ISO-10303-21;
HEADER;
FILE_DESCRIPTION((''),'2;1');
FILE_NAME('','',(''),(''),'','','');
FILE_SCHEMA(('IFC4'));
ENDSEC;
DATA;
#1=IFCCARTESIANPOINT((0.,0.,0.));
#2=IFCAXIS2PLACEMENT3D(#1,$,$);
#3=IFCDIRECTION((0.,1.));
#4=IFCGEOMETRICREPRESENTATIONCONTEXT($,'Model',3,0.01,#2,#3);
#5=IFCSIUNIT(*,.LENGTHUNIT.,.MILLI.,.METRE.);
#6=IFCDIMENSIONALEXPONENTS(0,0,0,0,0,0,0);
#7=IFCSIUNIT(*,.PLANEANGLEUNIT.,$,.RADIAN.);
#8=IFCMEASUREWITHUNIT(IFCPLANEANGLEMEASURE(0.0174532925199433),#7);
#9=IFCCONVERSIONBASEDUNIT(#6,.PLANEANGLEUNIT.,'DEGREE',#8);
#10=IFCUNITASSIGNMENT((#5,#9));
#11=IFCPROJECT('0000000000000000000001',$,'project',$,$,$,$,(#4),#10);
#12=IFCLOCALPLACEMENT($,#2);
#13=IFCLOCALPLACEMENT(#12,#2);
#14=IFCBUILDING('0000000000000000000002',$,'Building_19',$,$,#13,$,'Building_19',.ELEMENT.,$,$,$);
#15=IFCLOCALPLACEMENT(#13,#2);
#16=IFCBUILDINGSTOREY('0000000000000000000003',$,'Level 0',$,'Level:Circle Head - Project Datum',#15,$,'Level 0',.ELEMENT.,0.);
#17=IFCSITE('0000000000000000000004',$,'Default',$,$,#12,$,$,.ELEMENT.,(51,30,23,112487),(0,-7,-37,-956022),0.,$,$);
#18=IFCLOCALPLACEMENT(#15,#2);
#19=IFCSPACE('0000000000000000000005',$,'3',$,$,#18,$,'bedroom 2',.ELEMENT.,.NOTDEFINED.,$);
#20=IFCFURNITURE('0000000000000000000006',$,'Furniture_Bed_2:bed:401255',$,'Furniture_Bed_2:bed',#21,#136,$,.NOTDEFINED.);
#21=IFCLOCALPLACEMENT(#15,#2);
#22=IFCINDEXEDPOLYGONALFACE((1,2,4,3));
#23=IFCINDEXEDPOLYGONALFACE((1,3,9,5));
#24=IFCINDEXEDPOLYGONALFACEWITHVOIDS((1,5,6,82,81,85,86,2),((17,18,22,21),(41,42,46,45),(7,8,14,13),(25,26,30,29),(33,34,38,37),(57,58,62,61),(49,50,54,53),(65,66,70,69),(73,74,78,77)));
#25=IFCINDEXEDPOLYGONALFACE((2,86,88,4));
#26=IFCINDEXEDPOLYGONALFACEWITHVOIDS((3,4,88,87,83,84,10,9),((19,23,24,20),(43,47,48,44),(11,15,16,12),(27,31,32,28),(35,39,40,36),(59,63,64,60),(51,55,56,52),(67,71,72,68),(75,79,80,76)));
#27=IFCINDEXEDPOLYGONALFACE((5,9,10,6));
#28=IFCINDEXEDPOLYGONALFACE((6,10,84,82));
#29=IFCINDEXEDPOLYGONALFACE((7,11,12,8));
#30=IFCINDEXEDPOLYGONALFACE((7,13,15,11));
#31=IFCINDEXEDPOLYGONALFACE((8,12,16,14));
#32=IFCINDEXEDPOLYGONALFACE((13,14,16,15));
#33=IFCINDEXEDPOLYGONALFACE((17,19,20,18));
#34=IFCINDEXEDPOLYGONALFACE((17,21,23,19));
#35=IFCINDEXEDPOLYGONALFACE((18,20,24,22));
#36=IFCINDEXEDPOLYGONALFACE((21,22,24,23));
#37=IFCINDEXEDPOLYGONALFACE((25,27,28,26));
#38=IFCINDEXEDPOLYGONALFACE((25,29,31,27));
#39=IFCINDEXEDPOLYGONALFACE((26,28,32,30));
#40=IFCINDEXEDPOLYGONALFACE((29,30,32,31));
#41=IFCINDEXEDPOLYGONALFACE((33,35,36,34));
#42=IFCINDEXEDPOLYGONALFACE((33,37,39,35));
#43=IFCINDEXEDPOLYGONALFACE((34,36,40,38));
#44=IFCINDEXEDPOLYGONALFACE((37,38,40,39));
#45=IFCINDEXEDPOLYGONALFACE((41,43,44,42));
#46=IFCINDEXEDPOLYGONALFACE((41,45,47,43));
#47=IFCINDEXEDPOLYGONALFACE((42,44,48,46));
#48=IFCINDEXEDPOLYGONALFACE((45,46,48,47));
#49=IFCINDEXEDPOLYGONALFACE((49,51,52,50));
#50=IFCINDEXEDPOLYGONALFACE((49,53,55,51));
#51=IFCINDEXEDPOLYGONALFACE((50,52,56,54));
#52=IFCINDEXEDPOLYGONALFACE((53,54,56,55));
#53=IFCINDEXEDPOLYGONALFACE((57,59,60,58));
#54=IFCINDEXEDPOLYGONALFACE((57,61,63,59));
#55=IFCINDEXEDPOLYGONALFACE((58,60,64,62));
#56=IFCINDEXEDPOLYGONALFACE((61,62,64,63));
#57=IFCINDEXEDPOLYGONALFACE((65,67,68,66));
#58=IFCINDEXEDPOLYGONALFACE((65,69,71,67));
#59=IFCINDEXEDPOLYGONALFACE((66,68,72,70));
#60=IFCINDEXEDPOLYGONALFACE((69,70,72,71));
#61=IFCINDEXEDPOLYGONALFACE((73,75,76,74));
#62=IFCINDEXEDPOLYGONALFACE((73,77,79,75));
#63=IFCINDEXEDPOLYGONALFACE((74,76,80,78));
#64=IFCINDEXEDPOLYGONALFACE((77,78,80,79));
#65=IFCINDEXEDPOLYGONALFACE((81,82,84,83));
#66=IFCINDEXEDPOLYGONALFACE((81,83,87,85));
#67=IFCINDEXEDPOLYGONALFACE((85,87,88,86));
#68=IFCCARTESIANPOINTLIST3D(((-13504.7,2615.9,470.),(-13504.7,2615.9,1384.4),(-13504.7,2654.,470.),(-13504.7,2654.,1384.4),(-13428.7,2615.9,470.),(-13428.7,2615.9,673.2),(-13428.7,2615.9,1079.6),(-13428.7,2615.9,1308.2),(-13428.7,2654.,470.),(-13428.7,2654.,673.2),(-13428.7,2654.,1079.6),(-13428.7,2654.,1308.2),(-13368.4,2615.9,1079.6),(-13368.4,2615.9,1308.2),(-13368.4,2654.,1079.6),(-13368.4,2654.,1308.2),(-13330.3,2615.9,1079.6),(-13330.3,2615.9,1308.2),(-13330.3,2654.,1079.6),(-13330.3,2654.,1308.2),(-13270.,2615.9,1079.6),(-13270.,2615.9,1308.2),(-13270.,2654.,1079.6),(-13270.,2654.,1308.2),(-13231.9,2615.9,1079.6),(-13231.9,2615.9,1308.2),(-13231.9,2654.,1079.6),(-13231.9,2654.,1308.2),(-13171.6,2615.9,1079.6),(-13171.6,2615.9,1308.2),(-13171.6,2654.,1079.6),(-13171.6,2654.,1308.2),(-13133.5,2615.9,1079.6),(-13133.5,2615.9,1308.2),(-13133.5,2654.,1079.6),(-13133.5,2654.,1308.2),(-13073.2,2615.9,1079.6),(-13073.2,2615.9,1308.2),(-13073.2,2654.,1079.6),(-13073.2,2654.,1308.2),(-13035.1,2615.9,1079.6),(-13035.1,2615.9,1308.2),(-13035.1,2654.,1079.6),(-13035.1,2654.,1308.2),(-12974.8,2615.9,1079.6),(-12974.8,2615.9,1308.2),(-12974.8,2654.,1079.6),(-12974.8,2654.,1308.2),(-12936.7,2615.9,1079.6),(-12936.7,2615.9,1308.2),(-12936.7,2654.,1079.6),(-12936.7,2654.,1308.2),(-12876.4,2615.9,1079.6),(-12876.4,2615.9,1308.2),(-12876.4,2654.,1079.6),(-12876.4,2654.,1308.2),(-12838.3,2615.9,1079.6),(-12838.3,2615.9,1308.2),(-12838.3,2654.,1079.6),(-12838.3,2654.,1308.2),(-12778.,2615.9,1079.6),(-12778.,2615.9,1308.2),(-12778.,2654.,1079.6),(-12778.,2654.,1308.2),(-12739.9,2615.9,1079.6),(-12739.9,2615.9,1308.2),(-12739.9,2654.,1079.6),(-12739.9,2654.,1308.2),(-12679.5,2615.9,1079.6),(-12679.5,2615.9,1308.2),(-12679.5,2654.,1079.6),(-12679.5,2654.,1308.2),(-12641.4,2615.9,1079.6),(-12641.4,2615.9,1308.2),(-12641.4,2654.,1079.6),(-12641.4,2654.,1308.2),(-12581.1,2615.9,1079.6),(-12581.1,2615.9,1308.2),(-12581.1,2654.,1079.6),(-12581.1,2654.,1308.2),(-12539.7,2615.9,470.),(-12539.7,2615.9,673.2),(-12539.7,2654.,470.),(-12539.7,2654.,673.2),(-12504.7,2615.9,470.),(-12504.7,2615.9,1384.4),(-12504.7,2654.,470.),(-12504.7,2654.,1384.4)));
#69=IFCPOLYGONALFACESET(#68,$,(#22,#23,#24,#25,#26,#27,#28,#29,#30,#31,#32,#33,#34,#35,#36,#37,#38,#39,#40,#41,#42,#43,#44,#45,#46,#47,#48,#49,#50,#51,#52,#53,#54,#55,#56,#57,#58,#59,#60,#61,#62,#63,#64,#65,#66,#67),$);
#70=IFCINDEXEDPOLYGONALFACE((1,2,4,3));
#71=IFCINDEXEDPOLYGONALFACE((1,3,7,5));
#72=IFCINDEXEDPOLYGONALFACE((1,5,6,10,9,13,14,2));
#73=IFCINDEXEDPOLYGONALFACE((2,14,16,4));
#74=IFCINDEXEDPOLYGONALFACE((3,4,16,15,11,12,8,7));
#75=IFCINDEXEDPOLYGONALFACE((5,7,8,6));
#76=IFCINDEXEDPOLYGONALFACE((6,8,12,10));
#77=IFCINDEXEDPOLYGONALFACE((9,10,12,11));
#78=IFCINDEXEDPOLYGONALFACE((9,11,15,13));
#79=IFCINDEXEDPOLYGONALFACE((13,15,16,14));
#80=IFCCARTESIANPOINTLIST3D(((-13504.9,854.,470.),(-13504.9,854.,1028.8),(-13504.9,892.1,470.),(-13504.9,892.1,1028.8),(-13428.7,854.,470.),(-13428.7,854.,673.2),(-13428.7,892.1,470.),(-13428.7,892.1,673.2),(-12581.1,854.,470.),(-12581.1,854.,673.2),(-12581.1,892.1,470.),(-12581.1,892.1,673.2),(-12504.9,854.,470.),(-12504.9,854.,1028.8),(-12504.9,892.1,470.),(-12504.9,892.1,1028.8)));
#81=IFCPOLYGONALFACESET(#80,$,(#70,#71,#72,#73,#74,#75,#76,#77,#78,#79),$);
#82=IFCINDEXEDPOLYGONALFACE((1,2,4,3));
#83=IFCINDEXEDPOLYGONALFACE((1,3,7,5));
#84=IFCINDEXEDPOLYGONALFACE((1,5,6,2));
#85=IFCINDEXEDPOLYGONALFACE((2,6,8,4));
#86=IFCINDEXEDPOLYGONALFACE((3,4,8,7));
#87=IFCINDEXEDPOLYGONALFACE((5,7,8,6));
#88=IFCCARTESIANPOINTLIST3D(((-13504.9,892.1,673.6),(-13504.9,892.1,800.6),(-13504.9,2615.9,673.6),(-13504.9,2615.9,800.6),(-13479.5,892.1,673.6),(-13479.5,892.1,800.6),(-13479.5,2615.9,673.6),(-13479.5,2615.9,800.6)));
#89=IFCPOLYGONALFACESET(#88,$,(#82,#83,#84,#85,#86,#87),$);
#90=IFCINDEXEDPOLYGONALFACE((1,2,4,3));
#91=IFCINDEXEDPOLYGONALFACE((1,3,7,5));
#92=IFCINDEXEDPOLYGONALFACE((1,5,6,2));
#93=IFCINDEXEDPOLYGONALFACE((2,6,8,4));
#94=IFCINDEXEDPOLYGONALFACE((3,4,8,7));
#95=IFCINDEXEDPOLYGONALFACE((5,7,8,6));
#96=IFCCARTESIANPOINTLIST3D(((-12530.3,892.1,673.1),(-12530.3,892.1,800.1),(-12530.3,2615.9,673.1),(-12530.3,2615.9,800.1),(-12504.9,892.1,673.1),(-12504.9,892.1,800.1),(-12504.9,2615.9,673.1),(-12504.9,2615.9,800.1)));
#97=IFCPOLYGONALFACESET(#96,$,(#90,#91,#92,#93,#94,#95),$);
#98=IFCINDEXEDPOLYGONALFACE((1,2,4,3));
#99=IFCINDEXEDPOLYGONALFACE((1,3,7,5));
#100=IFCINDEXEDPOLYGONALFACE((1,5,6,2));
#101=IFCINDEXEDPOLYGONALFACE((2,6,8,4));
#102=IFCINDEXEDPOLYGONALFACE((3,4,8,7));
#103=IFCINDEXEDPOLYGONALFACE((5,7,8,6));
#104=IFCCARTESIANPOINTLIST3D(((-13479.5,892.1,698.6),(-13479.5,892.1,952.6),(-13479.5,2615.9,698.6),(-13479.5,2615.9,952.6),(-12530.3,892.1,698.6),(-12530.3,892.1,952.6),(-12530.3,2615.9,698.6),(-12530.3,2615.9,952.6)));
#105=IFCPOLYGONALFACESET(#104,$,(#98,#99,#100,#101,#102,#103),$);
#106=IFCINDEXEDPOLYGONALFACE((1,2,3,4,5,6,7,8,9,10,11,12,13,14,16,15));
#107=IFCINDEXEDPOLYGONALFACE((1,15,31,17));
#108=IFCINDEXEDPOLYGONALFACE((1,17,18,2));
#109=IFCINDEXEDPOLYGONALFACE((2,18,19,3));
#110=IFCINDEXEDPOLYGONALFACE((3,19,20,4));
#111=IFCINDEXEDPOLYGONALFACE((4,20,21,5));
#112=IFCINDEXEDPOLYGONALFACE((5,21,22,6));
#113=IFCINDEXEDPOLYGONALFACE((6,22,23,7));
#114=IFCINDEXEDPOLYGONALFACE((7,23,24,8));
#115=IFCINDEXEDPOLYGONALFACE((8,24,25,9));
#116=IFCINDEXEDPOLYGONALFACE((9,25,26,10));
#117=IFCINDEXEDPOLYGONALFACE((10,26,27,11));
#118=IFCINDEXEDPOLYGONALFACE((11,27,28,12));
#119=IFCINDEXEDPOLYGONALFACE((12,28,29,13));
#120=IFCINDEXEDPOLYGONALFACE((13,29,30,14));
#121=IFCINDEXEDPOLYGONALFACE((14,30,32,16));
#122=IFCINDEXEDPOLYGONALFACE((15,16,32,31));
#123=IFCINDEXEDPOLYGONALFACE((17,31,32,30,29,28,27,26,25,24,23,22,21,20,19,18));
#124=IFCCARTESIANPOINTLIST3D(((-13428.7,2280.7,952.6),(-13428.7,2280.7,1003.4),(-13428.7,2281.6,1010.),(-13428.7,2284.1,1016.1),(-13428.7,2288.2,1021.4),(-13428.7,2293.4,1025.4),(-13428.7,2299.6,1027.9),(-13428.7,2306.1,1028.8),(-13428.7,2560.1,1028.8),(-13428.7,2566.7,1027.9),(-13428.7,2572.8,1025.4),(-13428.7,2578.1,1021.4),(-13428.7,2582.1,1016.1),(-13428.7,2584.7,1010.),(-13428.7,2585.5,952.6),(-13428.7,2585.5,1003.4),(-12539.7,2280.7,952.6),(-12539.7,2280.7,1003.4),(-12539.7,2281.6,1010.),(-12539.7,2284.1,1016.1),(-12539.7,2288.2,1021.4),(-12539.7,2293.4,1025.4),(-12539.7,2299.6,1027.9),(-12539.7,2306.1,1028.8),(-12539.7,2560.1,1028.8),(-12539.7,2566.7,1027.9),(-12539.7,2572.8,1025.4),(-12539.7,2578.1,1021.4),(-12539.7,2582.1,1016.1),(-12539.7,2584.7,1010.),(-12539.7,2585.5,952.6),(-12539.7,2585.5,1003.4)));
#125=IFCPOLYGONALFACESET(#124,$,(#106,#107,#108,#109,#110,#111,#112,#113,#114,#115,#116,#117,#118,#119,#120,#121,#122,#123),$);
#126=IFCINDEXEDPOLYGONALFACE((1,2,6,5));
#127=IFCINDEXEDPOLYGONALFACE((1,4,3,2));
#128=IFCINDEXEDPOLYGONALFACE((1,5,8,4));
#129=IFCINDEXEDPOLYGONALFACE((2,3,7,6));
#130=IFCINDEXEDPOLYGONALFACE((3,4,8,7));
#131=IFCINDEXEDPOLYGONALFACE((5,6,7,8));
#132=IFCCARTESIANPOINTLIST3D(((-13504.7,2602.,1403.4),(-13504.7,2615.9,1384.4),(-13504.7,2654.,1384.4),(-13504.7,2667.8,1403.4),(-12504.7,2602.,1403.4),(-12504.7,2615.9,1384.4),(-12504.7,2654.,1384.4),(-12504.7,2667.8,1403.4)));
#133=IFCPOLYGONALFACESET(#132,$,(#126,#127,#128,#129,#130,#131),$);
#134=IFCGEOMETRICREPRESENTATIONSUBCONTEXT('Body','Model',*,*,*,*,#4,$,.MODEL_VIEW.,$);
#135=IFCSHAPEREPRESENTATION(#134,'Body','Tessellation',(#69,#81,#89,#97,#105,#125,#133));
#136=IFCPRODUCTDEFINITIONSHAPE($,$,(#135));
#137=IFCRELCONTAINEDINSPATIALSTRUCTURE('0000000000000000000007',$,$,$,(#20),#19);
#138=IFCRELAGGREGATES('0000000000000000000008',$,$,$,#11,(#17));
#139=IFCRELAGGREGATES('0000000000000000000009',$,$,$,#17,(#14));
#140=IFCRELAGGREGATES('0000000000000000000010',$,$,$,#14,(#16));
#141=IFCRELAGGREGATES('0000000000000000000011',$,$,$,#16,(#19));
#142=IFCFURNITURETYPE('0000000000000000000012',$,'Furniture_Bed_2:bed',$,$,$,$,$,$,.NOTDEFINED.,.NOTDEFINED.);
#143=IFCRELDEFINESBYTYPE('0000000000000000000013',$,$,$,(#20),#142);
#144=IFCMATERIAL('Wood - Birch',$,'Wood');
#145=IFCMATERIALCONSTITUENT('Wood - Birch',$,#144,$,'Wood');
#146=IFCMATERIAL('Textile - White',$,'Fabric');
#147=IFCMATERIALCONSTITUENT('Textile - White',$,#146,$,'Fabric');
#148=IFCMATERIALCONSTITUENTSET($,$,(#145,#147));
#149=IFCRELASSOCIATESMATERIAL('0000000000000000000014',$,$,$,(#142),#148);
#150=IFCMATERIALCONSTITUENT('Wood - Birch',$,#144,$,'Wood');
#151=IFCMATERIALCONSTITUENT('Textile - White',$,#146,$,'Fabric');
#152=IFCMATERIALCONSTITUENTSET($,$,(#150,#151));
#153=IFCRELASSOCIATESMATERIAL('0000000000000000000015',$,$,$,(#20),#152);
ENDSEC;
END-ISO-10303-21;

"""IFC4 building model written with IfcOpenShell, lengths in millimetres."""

from ifc_helpers import new_model, entity, si_unit, converted_unit, direction, frame, origin, place, context, subcontext, project, spatial, line, arc, indexed_curve, outline, extrude, source, transform, mapped, material, constituent, constituent_set, type_object, type_shapes, element, save


model = new_model("IFC4")

# Units and contexts
model_context = context("Model", 3, precision=0.01, world=origin(), true_north=direction((0.0, 1.0)))
body_context = subcontext(model_context, "Body", "Model", "MODEL_VIEW")
ifc_project = project(units=[si_unit("LENGTHUNIT", "METRE", prefix="MILLI"), converted_unit("PLANEANGLEUNIT", "DEGREE", entity("IfcPlaneAngleMeasure", 0.0174532925199433), si_unit("PLANEANGLEUNIT", "RADIAN"), dimensions=[0, 0, 0, 0, 0, 0, 0])], contexts=[model_context])

# Site, building, storey
site_placement = place(None, origin())
site = spatial("IfcSite", under=ifc_project, at=site_placement, Name="Default", CompositionType="ELEMENT", RefLatitude=(51, 30, 23, 112487), RefLongitude=(0, -7, -37, -956022), RefElevation=0.0)
building_placement = place(site_placement, origin())
building = spatial("IfcBuilding", under=site, at=building_placement, Name="Building_19", LongName="Building_19", CompositionType="ELEMENT")
storey_placement = place(building_placement, origin())
storey = spatial("IfcBuildingStorey", under=building, at=storey_placement, Name="Level 0", ObjectType="Level:Circle Head - Project Datum", LongName="Level 0", CompositionType="ELEMENT", Elevation=0.0)

# Shared definitions
space_1_placement = place(storey_placement, origin())
space_1 = spatial("IfcSpace", under=storey, at=space_1_placement, Name="3", LongName="bedroom 2", CompositionType="ELEMENT", PredefinedType="NOTDEFINED")

# Furniture
ifc_material_1 = material(Name="Wood - Birch", Category="Wood")
ifc_constituent_1 = constituent(ifc_material_1, Name="Wood - Birch", Category="Wood")
ifc_material_2 = material(Name="Textile - White", Category="Fabric")
ifc_constituent_2 = constituent(ifc_material_2, Name="Textile - White", Category="Fabric")
ifc_constituent_set_1 = constituent_set(constituents=[ifc_constituent_1, ifc_constituent_2])
ifc_constituent_3 = constituent(ifc_material_1, Name="Wood - Birch", Category="Wood")
ifc_constituent_4 = constituent(ifc_material_2, Name="Textile - White", Category="Fabric")
ifc_constituent_set_2 = constituent_set(constituents=[ifc_constituent_3, ifc_constituent_4])
furniture_type_1 = type_object("IfcFurnitureType", Name="Furniture_Bed_2:bed", AssemblyPlace="NOTDEFINED", PredefinedType="NOTDEFINED", material=ifc_constituent_set_2)
shared_shape_1 = source(origin(), body_context, "Body", "SweptSolid", [
    extrude(outline(indexed_curve([(-635.0, -489.8), (279.4, -489.8), (279.4, -454.7), (76.2, -454.7), (76.2, 434.3), (279.4, 434.3), (279.4, 510.3), (-635.0, 510.3), (-635.0, -489.8)], self_intersect=False), holes=[indexed_curve([(-558.8, 374.0), (-558.8, 434.3), (-330.2, 434.3), (-330.2, 374.0), (-558.8, 374.0)], self_intersect=False), indexed_curve([(-558.8, 275.5), (-558.8, 335.9), (-330.2, 335.9), (-330.2, 275.5), (-558.8, 275.5)], self_intersect=False), indexed_curve([(-558.8, 177.1), (-558.8, 237.4), (-330.2, 237.4), (-330.2, 177.1), (-558.8, 177.1)], self_intersect=False), indexed_curve([(-558.8, 78.7), (-558.8, 139.0), (-330.2, 139.0), (-330.2, 78.7), (-558.8, 78.7)], self_intersect=False), indexed_curve([(-558.8, -118.1), (-558.8, -57.8), (-330.2, -57.8), (-330.2, -118.1), (-558.8, -118.1)], self_intersect=False), indexed_curve([(-558.8, -216.5), (-558.8, -156.2), (-330.2, -156.2), (-330.2, -216.5), (-558.8, -216.5)], self_intersect=False), indexed_curve([(-558.8, -314.9), (-558.8, -254.6), (-330.2, -254.6), (-330.2, -314.9), (-558.8, -314.9)], self_intersect=False), indexed_curve([(-558.8, -413.3), (-558.8, -353.0), (-330.2, -353.0), (-330.2, -413.3), (-558.8, -413.3)], self_intersect=False), indexed_curve([(-558.8, -19.7), (-558.8, 40.6), (-330.2, 40.6), (-330.2, -19.7), (-558.8, -19.7)], self_intersect=False)]), frame((-8.6, -38.1, 279.4), z_axis=(0.0, 1.0, 0.0), x_axis=(0.0, 0.0, -1.0)), (0.0, 0.0, 1.0), 38.1),
    extrude(outline(indexed_curve([(423.8, -190.5), (500.0, -190.5), (500.0, 368.3), (-500.0, 368.3), (-500.0, -190.5), (-423.8, -190.5), (-423.8, 12.7), (423.8, 12.7), (423.8, -190.5)], self_intersect=False)), frame((-19.1, -1800.0, 190.5), z_axis=(0.0, 1.0, 0.0), x_axis=(-1.0, 0.0, 0.0)), (0.0, 0.0, 1.0), 38.1),
    extrude(outline(indexed_curve([(-12.7, -861.9), (12.7, -861.9), (12.7, 861.9), (-12.7, 861.9), (-12.7, -861.9)], self_intersect=False)), frame((-506.4, -900.0, 203.6)), (0.0, 0.0, 1.0), 127.0),
    extrude(outline(indexed_curve([(-12.7, -861.9), (12.7, -861.9), (12.7, 861.9), (-12.7, 861.9), (-12.7, -861.9)], self_intersect=False)), frame((468.2, -900.0, 203.1)), (0.0, 0.0, 1.0), 127.0),
    extrude(outline(indexed_curve([(-474.6, -861.9), (474.6, -861.9), (474.6, 861.9), (-474.6, 861.9), (-474.6, -861.9)], self_intersect=False)), frame((-19.0, -900.0, 228.6), z_axis=(0.0, 0.0, 1.0), x_axis=(-1.0, 0.0, 0.0)), (0.0, 0.0, 1.0), 254.0),
    extrude(outline(indexed_curve([(-152.4, -42.3), (152.4, -42.3), (152.4, 8.5), (145.0, 26.4), (127.0, 33.9), (-127.0, 33.9), (-145.0, 26.4), (-152.4, 8.5)], segments=[line(1, 2, 3), arc(3, 4, 5), line(5, 6), arc(6, 7, 8), line(8, 1)], self_intersect=False)), frame((-442.9, -220.8, 524.9), z_axis=(1.0, 0.0, 0.0), x_axis=(0.0, 1.0, 0.0)), (0.0, 0.0, 1.0), 889.0),
    extrude(outline(indexed_curve([(-19.1, -9.5), (19.0, -9.5), (32.9, 9.5), (-32.9, 9.5), (-19.1, -9.5)], self_intersect=False)), frame((-518.8, -19.0, 923.9), z_axis=(1.0, 0.0, 0.0), x_axis=(0.0, 1.0, 0.0)), (0.0, 0.0, 1.0), 1000.1),
])
type_shapes(furniture_type_1, [shared_shape_1])
furniture_1_placement = place(space_1_placement, frame((-12985.9, 2654.0, 470.0)))
element("IfcFurniture", 1, at=furniture_1_placement, inside=space_1, type_object=furniture_type_1, material=ifc_constituent_set_1, Name="Furniture_Bed_2:bed:401255", ObjectType="Furniture_Bed_2:bed", PredefinedType="NOTDEFINED", context=body_context, shape_type="MappedRepresentation", body=[
    mapped(shared_shape_1, transform((0.0, 0.0, 0.0), scale=1.0)),
])

save(model, "model.ifc")
